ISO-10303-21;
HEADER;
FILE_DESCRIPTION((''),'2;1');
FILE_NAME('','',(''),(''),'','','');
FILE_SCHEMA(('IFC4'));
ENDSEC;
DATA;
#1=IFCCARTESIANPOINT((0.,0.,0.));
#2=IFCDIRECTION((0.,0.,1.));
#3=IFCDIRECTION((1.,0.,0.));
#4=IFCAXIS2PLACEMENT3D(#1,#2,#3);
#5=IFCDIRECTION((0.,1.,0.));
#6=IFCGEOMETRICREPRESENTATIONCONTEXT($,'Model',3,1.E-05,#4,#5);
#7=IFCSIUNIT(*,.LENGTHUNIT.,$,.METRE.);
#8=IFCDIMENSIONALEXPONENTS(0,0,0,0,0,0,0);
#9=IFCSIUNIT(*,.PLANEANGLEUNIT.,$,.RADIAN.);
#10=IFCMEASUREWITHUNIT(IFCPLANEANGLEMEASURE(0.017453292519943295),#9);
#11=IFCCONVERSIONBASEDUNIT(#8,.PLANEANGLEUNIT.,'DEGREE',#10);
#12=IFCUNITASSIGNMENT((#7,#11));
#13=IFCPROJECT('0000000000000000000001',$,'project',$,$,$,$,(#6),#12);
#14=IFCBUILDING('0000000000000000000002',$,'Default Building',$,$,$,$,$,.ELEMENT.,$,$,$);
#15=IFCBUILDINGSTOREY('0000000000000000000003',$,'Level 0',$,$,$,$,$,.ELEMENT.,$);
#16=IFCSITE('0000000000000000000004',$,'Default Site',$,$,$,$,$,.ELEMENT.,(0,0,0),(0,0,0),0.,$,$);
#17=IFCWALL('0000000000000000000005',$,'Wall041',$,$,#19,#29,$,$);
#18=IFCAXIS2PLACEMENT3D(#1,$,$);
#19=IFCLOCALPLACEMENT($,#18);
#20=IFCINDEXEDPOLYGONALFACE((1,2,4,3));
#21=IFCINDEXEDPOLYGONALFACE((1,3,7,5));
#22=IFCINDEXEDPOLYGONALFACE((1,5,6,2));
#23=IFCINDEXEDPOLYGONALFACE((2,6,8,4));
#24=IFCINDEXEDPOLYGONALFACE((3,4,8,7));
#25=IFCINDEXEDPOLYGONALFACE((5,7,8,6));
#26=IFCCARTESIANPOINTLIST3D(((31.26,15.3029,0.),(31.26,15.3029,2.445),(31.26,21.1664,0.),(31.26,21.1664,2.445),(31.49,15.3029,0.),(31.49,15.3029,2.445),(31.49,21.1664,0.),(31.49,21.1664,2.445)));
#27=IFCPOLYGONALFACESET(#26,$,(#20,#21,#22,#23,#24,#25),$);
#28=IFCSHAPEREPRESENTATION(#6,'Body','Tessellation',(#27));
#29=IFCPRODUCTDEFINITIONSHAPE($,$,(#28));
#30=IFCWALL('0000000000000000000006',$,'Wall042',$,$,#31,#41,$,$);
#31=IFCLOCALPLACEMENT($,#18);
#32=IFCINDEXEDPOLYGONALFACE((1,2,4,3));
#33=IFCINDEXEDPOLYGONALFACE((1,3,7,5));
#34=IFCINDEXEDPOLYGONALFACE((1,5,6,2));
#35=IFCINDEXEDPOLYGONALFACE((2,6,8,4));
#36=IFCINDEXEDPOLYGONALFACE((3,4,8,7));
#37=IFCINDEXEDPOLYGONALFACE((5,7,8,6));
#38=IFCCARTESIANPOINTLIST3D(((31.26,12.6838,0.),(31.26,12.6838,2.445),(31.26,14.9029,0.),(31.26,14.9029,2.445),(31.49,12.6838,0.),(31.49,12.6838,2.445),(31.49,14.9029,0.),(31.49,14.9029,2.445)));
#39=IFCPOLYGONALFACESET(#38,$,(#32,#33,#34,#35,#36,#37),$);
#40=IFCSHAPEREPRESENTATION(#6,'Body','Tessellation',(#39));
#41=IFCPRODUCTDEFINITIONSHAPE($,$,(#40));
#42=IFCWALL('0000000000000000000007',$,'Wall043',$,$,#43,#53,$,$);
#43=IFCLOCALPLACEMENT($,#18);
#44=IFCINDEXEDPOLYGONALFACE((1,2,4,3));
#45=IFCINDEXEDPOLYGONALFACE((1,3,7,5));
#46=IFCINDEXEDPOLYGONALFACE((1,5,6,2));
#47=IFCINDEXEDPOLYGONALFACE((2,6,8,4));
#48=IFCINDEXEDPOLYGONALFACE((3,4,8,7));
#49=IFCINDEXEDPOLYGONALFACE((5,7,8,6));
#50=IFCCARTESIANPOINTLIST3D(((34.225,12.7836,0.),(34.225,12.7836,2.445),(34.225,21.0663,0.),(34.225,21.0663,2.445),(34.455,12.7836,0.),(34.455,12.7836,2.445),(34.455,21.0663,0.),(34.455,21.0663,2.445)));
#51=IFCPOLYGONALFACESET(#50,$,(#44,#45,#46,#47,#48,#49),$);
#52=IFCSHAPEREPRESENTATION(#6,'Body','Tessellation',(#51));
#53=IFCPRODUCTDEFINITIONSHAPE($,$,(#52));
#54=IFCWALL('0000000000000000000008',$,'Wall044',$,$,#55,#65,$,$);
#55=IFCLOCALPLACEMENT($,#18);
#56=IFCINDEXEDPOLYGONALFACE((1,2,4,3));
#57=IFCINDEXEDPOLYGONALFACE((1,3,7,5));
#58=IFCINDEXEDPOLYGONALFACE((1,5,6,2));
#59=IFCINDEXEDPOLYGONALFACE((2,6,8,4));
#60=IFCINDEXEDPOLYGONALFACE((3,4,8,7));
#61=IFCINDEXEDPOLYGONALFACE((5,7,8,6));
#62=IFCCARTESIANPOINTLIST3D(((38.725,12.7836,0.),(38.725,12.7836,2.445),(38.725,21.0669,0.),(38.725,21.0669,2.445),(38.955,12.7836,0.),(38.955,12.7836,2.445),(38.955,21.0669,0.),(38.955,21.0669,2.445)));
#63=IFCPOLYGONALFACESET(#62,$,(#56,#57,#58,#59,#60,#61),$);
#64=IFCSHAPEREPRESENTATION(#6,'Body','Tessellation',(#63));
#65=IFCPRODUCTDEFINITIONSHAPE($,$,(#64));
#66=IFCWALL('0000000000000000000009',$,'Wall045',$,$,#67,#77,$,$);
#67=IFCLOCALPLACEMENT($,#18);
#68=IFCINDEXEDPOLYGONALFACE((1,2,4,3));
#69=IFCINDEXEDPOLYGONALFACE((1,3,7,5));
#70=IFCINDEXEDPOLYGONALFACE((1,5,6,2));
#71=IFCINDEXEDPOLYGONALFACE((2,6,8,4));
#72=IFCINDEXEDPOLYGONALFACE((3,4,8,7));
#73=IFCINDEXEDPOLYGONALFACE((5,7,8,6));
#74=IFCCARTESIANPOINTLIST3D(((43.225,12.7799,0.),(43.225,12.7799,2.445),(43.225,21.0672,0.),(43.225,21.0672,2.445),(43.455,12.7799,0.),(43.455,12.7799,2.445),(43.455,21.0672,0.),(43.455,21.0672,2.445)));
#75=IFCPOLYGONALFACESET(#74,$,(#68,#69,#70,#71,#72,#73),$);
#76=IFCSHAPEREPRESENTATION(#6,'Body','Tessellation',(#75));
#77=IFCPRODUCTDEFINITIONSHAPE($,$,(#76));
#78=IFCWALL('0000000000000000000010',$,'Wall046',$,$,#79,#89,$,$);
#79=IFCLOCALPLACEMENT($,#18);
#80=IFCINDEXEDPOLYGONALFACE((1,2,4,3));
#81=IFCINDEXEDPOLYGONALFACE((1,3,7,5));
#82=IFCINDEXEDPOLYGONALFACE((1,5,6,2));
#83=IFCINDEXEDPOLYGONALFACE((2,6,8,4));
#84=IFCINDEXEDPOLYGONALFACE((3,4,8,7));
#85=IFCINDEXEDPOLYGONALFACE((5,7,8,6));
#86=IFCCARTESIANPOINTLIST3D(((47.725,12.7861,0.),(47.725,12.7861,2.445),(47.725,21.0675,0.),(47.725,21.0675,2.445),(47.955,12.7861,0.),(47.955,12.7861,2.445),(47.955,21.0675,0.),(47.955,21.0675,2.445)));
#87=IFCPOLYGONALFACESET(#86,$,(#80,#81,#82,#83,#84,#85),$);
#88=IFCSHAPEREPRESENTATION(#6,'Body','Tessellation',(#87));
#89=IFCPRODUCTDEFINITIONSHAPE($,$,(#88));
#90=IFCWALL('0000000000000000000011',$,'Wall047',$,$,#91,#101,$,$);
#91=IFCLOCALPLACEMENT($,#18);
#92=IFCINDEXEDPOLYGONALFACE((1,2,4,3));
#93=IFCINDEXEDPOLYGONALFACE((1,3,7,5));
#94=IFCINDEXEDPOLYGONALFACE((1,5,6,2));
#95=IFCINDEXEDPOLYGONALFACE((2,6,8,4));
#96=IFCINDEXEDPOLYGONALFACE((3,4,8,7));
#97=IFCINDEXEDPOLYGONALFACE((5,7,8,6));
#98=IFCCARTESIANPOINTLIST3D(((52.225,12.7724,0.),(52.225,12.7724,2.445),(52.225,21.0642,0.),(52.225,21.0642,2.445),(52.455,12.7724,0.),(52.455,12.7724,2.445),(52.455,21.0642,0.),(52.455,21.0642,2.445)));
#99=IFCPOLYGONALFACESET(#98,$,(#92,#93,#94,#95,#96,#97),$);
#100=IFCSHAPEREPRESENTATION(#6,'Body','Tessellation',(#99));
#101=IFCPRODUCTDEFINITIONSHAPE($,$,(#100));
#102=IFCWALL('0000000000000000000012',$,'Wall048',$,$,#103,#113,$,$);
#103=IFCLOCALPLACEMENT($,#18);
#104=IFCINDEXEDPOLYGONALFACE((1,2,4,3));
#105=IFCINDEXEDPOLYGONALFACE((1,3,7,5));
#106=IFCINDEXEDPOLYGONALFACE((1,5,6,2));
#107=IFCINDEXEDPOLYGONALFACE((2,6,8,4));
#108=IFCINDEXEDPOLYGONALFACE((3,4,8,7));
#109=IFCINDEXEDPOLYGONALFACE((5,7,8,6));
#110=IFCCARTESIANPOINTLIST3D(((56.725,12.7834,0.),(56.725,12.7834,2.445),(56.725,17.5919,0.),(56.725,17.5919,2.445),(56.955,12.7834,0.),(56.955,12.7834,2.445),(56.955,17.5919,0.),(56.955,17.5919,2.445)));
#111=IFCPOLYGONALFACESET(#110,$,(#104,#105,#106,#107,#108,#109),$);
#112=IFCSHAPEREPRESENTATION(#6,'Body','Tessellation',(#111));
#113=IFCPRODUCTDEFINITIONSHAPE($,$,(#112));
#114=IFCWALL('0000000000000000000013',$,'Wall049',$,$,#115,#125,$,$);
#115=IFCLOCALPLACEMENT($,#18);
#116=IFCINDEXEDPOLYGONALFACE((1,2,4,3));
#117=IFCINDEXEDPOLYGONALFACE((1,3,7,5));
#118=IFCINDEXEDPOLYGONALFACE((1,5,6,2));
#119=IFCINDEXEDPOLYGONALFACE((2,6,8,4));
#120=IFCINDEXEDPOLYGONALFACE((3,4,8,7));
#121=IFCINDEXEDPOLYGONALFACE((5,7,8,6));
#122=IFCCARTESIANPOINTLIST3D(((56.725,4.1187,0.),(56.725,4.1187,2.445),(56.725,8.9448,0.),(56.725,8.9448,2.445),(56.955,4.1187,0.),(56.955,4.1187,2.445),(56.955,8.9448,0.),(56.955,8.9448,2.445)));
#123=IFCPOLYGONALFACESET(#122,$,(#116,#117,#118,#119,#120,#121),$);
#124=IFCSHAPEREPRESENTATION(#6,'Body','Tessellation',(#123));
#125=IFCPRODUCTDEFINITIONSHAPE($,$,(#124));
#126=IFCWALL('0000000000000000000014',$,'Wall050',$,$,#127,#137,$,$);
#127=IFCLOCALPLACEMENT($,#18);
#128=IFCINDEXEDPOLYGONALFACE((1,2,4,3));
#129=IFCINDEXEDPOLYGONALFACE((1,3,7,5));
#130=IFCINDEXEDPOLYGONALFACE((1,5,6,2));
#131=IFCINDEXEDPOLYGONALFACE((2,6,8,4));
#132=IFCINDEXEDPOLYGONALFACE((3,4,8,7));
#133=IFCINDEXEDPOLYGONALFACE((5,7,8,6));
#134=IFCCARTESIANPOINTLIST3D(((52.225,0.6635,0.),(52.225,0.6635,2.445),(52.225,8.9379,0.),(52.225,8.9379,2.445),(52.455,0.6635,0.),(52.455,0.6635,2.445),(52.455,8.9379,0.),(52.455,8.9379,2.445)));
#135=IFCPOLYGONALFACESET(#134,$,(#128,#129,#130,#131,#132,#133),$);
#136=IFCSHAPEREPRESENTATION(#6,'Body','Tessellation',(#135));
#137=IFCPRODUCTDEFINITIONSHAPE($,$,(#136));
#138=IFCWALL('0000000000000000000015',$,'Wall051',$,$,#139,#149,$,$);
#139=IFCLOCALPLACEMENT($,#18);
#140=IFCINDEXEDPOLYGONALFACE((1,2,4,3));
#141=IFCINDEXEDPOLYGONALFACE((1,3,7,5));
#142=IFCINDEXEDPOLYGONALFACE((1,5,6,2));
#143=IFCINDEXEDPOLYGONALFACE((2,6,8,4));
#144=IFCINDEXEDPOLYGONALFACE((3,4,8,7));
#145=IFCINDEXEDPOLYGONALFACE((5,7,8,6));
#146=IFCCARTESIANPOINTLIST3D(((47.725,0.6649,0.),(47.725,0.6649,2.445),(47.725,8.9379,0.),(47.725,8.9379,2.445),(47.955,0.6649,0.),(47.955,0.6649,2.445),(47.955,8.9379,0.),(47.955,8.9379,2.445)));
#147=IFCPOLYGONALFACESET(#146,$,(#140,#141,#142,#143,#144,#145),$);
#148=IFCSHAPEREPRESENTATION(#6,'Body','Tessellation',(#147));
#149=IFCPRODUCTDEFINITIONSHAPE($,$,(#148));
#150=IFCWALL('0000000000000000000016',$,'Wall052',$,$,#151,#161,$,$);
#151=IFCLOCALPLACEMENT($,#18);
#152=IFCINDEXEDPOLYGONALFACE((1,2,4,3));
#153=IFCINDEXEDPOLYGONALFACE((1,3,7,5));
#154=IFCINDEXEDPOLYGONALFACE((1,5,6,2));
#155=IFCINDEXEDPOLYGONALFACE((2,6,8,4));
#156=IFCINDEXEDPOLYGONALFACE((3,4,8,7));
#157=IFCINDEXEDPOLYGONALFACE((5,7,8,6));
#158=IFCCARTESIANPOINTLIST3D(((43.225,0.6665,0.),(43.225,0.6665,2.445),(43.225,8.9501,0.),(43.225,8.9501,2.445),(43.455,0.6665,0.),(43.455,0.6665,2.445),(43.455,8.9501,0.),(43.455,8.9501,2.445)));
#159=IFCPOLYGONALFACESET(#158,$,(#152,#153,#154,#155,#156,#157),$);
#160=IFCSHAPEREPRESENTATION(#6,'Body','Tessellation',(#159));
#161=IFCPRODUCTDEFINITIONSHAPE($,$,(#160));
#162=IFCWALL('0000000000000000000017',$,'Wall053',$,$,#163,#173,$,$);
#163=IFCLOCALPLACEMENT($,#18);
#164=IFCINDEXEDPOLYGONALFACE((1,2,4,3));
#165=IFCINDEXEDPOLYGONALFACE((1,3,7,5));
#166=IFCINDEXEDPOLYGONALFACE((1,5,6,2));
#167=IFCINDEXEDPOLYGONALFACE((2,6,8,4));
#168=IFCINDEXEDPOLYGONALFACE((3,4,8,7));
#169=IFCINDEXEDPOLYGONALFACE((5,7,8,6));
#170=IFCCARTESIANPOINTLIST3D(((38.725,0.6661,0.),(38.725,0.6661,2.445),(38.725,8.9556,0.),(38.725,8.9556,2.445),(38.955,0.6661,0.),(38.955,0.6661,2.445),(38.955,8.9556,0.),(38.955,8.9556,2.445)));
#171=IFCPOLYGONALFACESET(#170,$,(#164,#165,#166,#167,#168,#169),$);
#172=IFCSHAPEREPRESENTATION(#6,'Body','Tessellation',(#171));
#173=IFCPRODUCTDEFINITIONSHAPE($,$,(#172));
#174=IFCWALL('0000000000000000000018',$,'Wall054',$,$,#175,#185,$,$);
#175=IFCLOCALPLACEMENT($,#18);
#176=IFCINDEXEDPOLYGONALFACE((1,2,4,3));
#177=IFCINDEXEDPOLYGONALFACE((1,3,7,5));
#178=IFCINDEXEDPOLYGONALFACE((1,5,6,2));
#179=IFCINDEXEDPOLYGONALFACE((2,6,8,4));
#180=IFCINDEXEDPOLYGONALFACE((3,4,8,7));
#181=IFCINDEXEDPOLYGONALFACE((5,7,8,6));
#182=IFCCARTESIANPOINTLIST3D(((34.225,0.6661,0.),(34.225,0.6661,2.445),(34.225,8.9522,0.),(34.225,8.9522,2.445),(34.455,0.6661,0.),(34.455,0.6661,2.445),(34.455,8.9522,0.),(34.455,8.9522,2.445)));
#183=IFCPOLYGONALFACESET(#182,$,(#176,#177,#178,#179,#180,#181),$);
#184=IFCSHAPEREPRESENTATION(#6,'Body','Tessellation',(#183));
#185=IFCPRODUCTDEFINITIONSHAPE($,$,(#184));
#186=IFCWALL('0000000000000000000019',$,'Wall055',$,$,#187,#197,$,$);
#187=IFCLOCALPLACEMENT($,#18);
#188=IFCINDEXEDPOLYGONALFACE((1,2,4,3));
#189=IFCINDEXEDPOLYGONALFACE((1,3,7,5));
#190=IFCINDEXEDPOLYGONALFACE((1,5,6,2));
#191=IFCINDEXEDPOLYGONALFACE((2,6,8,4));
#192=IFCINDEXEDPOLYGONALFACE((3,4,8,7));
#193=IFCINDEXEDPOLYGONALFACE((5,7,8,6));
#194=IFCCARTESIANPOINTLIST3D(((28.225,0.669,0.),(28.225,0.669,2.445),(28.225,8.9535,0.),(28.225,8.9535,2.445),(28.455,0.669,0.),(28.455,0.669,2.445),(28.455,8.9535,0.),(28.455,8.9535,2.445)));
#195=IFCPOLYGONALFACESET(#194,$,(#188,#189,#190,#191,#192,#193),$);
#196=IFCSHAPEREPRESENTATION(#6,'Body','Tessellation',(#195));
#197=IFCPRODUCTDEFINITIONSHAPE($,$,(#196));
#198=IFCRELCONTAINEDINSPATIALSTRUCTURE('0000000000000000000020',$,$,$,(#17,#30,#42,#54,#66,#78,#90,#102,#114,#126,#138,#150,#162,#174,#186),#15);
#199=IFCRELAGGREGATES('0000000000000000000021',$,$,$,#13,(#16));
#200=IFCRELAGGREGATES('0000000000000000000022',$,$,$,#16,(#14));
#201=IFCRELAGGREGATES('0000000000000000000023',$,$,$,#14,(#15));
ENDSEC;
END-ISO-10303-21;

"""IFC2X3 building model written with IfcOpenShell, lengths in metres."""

from ifc_helpers import new_model, entity, si_unit, converted_unit, direction, frame, frame_2d, origin_with_axes, place, context, project, spatial, rectangle, extrude, element, save


model = new_model("IFC2X3")

# Units and contexts
model_context = context("Model", 3, precision=1e-05, world=origin_with_axes(), true_north=direction((0.0, 1.0, 0.0)))
ifc_project = project(units=[si_unit("LENGTHUNIT", "METRE"), converted_unit("PLANEANGLEUNIT", "DEGREE", entity("IfcPlaneAngleMeasure", 0.017453292519943295), si_unit("PLANEANGLEUNIT", "RADIAN"), dimensions=[0, 0, 0, 0, 0, 0, 0])], contexts=[model_context])

# Site, building, storey
site = spatial("IfcSite", under=ifc_project, Name="Default Site", CompositionType="ELEMENT", RefLatitude=(0, 0, 0), RefLongitude=(0, 0, 0), RefElevation=0.0)
building = spatial("IfcBuilding", under=site, Name="Default Building", CompositionType="ELEMENT")
storey = spatial("IfcBuildingStorey", under=building, Name="Level 0", CompositionType="ELEMENT")

# Shared definitions
placement = place(None, origin_with_axes())

# Walls
element("IfcWall", 1, at=placement, inside=storey, Name="Wall041", context=model_context, shape_type="SweptSolid", body=[
    extrude(rectangle(XDim=5.8635, YDim=0.23, at=frame_2d((0.0, 0.0), x_axis=(0.0, -1.0, 0.0))), frame((31.375, 18.2346, 0.0), z_axis=(0.0, 0.0, 1.0), x_axis=(1.0, 0.0, 0.0)), (0.0, 0.0, 1.0), 2.445),
])
element("IfcWall", 2, at=placement, inside=storey, Name="Wall042", context=model_context, shape_type="SweptSolid", body=[
    extrude(rectangle(XDim=2.2191, YDim=0.23, at=frame_2d((0.0, 0.0), x_axis=(0.0, 1.0, 0.0))), frame((31.375, 13.7934, 0.0), z_axis=(0.0, 0.0, 1.0), x_axis=(1.0, 0.0, 0.0)), (0.0, 0.0, 1.0), 2.445),
])
element("IfcWall", 3, at=placement, inside=storey, Name="Wall043", context=model_context, shape_type="SweptSolid", body=[
    extrude(rectangle(XDim=8.2827, YDim=0.23, at=frame_2d((0.0, 0.0), x_axis=(0.0, -1.0, 0.0))), frame((34.34, 16.925, 0.0), z_axis=(0.0, 0.0, 1.0), x_axis=(1.0, 0.0, 0.0)), (0.0, 0.0, 1.0), 2.445),
])
element("IfcWall", 4, at=placement, inside=storey, Name="Wall044", context=model_context, shape_type="SweptSolid", body=[
    extrude(rectangle(XDim=8.2833, YDim=0.23, at=frame_2d((0.0, 0.0), x_axis=(0.0, -1.0, 0.0))), frame((38.84, 16.9253, 0.0), z_axis=(0.0, 0.0, 1.0), x_axis=(1.0, 0.0, 0.0)), (0.0, 0.0, 1.0), 2.445),
])
element("IfcWall", 5, at=placement, inside=storey, Name="Wall045", context=model_context, shape_type="SweptSolid", body=[
    extrude(rectangle(XDim=8.2873, YDim=0.23, at=frame_2d((0.0, 0.0), x_axis=(0.0, 1.0, 0.0))), frame((43.34, 16.9235, 0.0), z_axis=(0.0, 0.0, 1.0), x_axis=(1.0, 0.0, 0.0)), (0.0, 0.0, 1.0), 2.445),
])
element("IfcWall", 6, at=placement, inside=storey, Name="Wall046", context=model_context, shape_type="SweptSolid", body=[
    extrude(rectangle(XDim=8.2814, YDim=0.23, at=frame_2d((0.0, 0.0), x_axis=(0.0, -1.0, 0.0))), frame((47.84, 16.9268, 0.0), z_axis=(0.0, 0.0, 1.0), x_axis=(1.0, 0.0, 0.0)), (0.0, 0.0, 1.0), 2.445),
])
element("IfcWall", 7, at=placement, inside=storey, Name="Wall047", context=model_context, shape_type="SweptSolid", body=[
    extrude(rectangle(XDim=8.2918, YDim=0.23, at=frame_2d((0.0, 0.0), x_axis=(0.0, -1.0, 0.0))), frame((52.34, 16.9183, 0.0), z_axis=(0.0, 0.0, 1.0), x_axis=(1.0, 0.0, 0.0)), (0.0, 0.0, 1.0), 2.445),
])
element("IfcWall", 8, at=placement, inside=storey, Name="Wall048", context=model_context, shape_type="SweptSolid", body=[
    extrude(rectangle(XDim=4.8085, YDim=0.23, at=frame_2d((0.0, 0.0), x_axis=(0.0, 1.0, 0.0))), frame((56.84, 15.1877, 0.0), z_axis=(0.0, 0.0, 1.0), x_axis=(1.0, 0.0, 0.0)), (0.0, 0.0, 1.0), 2.445),
])
element("IfcWall", 9, at=placement, inside=storey, Name="Wall049", context=model_context, shape_type="SweptSolid", body=[
    extrude(rectangle(XDim=4.8261, YDim=0.23, at=frame_2d((0.0, 0.0), x_axis=(0.0, -1.0, 0.0))), frame((56.84, 6.5318, 0.0), z_axis=(0.0, 0.0, 1.0), x_axis=(1.0, 0.0, 0.0)), (0.0, 0.0, 1.0), 2.445),
])
element("IfcWall", 10, at=placement, inside=storey, Name="Wall050", context=model_context, shape_type="SweptSolid", body=[
    extrude(rectangle(XDim=8.2744, YDim=0.23, at=frame_2d((0.0, 0.0), x_axis=(0.0, 1.0, 0.0))), frame((52.34, 4.8007, 0.0), z_axis=(0.0, 0.0, 1.0), x_axis=(1.0, 0.0, 0.0)), (0.0, 0.0, 1.0), 2.445),
])
element("IfcWall", 11, at=placement, inside=storey, Name="Wall051", context=model_context, shape_type="SweptSolid", body=[
    extrude(rectangle(XDim=8.273, YDim=0.23, at=frame_2d((0.0, 0.0), x_axis=(0.0, -1.0, 0.0))), frame((47.84, 4.8014, 0.0), z_axis=(0.0, 0.0, 1.0), x_axis=(1.0, 0.0, 0.0)), (0.0, 0.0, 1.0), 2.445),
])
element("IfcWall", 12, at=placement, inside=storey, Name="Wall052", context=model_context, shape_type="SweptSolid", body=[
    extrude(rectangle(XDim=8.2836, YDim=0.23, at=frame_2d((0.0, 0.0), x_axis=(0.0, 1.0, 0.0))), frame((43.34, 4.8083, 0.0), z_axis=(0.0, 0.0, 1.0), x_axis=(1.0, 0.0, 0.0)), (0.0, 0.0, 1.0), 2.445),
])
element("IfcWall", 13, at=placement, inside=storey, Name="Wall053", context=model_context, shape_type="SweptSolid", body=[
    extrude(rectangle(XDim=8.2895, YDim=0.23, at=frame_2d((0.0, 0.0), x_axis=(0.0, -1.0, 0.0))), frame((38.84, 4.8109, 0.0), z_axis=(0.0, 0.0, 1.0), x_axis=(1.0, 0.0, 0.0)), (0.0, 0.0, 1.0), 2.445),
])
element("IfcWall", 14, at=placement, inside=storey, Name="Wall054", context=model_context, shape_type="SweptSolid", body=[
    extrude(rectangle(XDim=8.2861, YDim=0.23, at=frame_2d((0.0, 0.0), x_axis=(0.0, -1.0, 0.0))), frame((34.34, 4.8092, 0.0), z_axis=(0.0, 0.0, 1.0), x_axis=(1.0, 0.0, 0.0)), (0.0, 0.0, 1.0), 2.445),
])
element("IfcWall", 15, at=placement, inside=storey, Name="Wall055", context=model_context, shape_type="SweptSolid", body=[
    extrude(rectangle(XDim=8.2845, YDim=0.23, at=frame_2d((0.0, 0.0), x_axis=(0.0, 1.0, 0.0))), frame((28.34, 4.8113, 0.0), z_axis=(0.0, 0.0, 1.0), x_axis=(1.0, 0.0, 0.0)), (0.0, 0.0, 1.0), 2.445),
])

save(model, "model.ifc")
